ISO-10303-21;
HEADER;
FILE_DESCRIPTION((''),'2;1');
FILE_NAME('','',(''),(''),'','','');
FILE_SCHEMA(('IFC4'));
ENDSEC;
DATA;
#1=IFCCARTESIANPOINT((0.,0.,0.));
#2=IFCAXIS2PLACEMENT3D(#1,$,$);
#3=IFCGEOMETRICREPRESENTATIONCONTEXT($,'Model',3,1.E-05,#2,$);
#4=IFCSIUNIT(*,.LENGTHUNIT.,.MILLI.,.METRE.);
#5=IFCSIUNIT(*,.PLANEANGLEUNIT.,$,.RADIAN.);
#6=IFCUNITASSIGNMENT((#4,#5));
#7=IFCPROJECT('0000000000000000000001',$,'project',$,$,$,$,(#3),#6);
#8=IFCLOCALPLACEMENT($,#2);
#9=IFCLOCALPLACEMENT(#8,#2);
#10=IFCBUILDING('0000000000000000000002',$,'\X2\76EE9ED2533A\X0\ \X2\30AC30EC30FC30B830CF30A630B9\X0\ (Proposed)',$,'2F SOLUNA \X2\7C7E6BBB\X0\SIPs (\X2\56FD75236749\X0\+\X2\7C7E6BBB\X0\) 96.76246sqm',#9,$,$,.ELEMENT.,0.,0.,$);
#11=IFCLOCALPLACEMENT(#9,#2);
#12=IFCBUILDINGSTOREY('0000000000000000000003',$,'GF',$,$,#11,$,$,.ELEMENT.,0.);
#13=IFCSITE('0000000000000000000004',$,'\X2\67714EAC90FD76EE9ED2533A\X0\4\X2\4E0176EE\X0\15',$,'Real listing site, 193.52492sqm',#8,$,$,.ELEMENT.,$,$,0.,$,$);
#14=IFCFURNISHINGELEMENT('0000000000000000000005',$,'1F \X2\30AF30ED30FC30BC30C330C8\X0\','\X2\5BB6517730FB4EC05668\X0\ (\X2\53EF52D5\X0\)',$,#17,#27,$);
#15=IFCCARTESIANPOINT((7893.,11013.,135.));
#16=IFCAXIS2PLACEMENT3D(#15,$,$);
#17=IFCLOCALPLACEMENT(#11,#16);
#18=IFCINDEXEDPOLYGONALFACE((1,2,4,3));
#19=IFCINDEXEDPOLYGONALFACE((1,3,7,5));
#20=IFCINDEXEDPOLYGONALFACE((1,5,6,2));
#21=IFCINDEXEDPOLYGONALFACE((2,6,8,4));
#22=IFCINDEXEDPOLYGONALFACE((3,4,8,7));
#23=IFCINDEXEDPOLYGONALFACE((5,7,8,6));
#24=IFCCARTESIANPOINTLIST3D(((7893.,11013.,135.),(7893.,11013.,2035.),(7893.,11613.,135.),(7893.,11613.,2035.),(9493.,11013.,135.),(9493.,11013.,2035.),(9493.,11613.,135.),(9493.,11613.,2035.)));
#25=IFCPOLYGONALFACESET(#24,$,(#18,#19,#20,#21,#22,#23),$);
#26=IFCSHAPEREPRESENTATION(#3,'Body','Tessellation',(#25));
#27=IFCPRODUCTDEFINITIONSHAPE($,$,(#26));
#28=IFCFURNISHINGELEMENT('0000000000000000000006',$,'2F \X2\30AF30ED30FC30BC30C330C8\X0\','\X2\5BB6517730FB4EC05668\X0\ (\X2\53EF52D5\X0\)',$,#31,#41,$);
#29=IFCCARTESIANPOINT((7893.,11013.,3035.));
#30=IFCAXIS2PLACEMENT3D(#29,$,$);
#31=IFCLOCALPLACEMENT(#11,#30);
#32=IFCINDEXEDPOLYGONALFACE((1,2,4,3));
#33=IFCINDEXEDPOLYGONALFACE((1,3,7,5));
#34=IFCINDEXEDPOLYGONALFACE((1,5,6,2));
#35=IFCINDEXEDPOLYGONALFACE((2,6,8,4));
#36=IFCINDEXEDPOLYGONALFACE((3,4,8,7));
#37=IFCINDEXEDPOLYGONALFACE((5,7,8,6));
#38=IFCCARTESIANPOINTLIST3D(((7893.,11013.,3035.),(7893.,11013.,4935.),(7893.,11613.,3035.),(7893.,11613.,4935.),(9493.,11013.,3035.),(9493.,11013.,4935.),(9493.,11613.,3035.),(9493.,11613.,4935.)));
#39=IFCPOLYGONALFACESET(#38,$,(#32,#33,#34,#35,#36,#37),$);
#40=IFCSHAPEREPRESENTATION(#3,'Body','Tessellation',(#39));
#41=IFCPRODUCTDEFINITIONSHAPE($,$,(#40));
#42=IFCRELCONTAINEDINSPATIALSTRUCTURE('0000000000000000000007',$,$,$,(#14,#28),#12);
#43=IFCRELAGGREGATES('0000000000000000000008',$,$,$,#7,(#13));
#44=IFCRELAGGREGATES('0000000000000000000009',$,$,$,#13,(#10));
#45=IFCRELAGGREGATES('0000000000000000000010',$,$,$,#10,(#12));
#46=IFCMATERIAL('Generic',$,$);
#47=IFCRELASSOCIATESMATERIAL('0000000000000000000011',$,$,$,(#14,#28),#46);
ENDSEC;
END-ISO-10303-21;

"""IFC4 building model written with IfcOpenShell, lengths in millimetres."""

from ifc_helpers import new_model, si_unit, frame, frame_2d, origin, place, context, project, spatial, rectangle, extrude, material, element, save


model = new_model("IFC4")

# Units and contexts
model_context = context("Model", 3, precision=1e-05, world=origin())
ifc_project = project(units=[si_unit("LENGTHUNIT", "METRE", prefix="MILLI"), si_unit("PLANEANGLEUNIT", "RADIAN")], contexts=[model_context])

# Site, building, storey
site_placement = place(None, origin())
site = spatial("IfcSite", under=ifc_project, at=site_placement, Name="東京都目黒区4丁目15", ObjectType="Real listing site, 193.52492sqm", CompositionType="ELEMENT", RefElevation=0.0)
building_placement = place(site_placement, origin())
building = spatial("IfcBuilding", under=site, at=building_placement, Name="目黒区 ガレージハウス (Proposed)", ObjectType="2F SOLUNA 籾殻SIPs (国産杉+籾殻) 96.76246sqm", CompositionType="ELEMENT", ElevationOfRefHeight=0.0, ElevationOfTerrain=0.0)
storey_placement = place(building_placement, origin())
storey = spatial("IfcBuildingStorey", under=building, at=storey_placement, Name="GF", CompositionType="ELEMENT", Elevation=0.0)

# Shared definitions
ifc_material_1 = material(Name="Generic")

# Furnishing elements
furnishing_1_placement = place(storey_placement, frame((7893.0, 11013.0, 135.0)))
element("IfcFurnishingElement", 1, at=furnishing_1_placement, inside=storey, material=ifc_material_1, Name="1F クローゼット", Description="家具・什器 (可動)", context=model_context, shape_type="SweptSolid", body=[
    extrude(rectangle(XDim=1600.0, YDim=600.0, at=frame_2d((800.0, 300.0))), frame((7893.0, 11013.0, 135.0)), (0.0, 0.0, 1.0), 1900.0),
])
furnishing_2_placement = place(storey_placement, frame((7893.0, 11013.0, 3035.0)))
element("IfcFurnishingElement", 2, at=furnishing_2_placement, inside=storey, material=ifc_material_1, Name="2F クローゼット", Description="家具・什器 (可動)", context=model_context, shape_type="SweptSolid", body=[
    extrude(rectangle(XDim=1600.0, YDim=600.0, at=frame_2d((800.0, 300.0))), frame((7893.0, 11013.0, 3035.0)), (0.0, 0.0, 1.0), 1900.0),
])

save(model, "model.ifc")
